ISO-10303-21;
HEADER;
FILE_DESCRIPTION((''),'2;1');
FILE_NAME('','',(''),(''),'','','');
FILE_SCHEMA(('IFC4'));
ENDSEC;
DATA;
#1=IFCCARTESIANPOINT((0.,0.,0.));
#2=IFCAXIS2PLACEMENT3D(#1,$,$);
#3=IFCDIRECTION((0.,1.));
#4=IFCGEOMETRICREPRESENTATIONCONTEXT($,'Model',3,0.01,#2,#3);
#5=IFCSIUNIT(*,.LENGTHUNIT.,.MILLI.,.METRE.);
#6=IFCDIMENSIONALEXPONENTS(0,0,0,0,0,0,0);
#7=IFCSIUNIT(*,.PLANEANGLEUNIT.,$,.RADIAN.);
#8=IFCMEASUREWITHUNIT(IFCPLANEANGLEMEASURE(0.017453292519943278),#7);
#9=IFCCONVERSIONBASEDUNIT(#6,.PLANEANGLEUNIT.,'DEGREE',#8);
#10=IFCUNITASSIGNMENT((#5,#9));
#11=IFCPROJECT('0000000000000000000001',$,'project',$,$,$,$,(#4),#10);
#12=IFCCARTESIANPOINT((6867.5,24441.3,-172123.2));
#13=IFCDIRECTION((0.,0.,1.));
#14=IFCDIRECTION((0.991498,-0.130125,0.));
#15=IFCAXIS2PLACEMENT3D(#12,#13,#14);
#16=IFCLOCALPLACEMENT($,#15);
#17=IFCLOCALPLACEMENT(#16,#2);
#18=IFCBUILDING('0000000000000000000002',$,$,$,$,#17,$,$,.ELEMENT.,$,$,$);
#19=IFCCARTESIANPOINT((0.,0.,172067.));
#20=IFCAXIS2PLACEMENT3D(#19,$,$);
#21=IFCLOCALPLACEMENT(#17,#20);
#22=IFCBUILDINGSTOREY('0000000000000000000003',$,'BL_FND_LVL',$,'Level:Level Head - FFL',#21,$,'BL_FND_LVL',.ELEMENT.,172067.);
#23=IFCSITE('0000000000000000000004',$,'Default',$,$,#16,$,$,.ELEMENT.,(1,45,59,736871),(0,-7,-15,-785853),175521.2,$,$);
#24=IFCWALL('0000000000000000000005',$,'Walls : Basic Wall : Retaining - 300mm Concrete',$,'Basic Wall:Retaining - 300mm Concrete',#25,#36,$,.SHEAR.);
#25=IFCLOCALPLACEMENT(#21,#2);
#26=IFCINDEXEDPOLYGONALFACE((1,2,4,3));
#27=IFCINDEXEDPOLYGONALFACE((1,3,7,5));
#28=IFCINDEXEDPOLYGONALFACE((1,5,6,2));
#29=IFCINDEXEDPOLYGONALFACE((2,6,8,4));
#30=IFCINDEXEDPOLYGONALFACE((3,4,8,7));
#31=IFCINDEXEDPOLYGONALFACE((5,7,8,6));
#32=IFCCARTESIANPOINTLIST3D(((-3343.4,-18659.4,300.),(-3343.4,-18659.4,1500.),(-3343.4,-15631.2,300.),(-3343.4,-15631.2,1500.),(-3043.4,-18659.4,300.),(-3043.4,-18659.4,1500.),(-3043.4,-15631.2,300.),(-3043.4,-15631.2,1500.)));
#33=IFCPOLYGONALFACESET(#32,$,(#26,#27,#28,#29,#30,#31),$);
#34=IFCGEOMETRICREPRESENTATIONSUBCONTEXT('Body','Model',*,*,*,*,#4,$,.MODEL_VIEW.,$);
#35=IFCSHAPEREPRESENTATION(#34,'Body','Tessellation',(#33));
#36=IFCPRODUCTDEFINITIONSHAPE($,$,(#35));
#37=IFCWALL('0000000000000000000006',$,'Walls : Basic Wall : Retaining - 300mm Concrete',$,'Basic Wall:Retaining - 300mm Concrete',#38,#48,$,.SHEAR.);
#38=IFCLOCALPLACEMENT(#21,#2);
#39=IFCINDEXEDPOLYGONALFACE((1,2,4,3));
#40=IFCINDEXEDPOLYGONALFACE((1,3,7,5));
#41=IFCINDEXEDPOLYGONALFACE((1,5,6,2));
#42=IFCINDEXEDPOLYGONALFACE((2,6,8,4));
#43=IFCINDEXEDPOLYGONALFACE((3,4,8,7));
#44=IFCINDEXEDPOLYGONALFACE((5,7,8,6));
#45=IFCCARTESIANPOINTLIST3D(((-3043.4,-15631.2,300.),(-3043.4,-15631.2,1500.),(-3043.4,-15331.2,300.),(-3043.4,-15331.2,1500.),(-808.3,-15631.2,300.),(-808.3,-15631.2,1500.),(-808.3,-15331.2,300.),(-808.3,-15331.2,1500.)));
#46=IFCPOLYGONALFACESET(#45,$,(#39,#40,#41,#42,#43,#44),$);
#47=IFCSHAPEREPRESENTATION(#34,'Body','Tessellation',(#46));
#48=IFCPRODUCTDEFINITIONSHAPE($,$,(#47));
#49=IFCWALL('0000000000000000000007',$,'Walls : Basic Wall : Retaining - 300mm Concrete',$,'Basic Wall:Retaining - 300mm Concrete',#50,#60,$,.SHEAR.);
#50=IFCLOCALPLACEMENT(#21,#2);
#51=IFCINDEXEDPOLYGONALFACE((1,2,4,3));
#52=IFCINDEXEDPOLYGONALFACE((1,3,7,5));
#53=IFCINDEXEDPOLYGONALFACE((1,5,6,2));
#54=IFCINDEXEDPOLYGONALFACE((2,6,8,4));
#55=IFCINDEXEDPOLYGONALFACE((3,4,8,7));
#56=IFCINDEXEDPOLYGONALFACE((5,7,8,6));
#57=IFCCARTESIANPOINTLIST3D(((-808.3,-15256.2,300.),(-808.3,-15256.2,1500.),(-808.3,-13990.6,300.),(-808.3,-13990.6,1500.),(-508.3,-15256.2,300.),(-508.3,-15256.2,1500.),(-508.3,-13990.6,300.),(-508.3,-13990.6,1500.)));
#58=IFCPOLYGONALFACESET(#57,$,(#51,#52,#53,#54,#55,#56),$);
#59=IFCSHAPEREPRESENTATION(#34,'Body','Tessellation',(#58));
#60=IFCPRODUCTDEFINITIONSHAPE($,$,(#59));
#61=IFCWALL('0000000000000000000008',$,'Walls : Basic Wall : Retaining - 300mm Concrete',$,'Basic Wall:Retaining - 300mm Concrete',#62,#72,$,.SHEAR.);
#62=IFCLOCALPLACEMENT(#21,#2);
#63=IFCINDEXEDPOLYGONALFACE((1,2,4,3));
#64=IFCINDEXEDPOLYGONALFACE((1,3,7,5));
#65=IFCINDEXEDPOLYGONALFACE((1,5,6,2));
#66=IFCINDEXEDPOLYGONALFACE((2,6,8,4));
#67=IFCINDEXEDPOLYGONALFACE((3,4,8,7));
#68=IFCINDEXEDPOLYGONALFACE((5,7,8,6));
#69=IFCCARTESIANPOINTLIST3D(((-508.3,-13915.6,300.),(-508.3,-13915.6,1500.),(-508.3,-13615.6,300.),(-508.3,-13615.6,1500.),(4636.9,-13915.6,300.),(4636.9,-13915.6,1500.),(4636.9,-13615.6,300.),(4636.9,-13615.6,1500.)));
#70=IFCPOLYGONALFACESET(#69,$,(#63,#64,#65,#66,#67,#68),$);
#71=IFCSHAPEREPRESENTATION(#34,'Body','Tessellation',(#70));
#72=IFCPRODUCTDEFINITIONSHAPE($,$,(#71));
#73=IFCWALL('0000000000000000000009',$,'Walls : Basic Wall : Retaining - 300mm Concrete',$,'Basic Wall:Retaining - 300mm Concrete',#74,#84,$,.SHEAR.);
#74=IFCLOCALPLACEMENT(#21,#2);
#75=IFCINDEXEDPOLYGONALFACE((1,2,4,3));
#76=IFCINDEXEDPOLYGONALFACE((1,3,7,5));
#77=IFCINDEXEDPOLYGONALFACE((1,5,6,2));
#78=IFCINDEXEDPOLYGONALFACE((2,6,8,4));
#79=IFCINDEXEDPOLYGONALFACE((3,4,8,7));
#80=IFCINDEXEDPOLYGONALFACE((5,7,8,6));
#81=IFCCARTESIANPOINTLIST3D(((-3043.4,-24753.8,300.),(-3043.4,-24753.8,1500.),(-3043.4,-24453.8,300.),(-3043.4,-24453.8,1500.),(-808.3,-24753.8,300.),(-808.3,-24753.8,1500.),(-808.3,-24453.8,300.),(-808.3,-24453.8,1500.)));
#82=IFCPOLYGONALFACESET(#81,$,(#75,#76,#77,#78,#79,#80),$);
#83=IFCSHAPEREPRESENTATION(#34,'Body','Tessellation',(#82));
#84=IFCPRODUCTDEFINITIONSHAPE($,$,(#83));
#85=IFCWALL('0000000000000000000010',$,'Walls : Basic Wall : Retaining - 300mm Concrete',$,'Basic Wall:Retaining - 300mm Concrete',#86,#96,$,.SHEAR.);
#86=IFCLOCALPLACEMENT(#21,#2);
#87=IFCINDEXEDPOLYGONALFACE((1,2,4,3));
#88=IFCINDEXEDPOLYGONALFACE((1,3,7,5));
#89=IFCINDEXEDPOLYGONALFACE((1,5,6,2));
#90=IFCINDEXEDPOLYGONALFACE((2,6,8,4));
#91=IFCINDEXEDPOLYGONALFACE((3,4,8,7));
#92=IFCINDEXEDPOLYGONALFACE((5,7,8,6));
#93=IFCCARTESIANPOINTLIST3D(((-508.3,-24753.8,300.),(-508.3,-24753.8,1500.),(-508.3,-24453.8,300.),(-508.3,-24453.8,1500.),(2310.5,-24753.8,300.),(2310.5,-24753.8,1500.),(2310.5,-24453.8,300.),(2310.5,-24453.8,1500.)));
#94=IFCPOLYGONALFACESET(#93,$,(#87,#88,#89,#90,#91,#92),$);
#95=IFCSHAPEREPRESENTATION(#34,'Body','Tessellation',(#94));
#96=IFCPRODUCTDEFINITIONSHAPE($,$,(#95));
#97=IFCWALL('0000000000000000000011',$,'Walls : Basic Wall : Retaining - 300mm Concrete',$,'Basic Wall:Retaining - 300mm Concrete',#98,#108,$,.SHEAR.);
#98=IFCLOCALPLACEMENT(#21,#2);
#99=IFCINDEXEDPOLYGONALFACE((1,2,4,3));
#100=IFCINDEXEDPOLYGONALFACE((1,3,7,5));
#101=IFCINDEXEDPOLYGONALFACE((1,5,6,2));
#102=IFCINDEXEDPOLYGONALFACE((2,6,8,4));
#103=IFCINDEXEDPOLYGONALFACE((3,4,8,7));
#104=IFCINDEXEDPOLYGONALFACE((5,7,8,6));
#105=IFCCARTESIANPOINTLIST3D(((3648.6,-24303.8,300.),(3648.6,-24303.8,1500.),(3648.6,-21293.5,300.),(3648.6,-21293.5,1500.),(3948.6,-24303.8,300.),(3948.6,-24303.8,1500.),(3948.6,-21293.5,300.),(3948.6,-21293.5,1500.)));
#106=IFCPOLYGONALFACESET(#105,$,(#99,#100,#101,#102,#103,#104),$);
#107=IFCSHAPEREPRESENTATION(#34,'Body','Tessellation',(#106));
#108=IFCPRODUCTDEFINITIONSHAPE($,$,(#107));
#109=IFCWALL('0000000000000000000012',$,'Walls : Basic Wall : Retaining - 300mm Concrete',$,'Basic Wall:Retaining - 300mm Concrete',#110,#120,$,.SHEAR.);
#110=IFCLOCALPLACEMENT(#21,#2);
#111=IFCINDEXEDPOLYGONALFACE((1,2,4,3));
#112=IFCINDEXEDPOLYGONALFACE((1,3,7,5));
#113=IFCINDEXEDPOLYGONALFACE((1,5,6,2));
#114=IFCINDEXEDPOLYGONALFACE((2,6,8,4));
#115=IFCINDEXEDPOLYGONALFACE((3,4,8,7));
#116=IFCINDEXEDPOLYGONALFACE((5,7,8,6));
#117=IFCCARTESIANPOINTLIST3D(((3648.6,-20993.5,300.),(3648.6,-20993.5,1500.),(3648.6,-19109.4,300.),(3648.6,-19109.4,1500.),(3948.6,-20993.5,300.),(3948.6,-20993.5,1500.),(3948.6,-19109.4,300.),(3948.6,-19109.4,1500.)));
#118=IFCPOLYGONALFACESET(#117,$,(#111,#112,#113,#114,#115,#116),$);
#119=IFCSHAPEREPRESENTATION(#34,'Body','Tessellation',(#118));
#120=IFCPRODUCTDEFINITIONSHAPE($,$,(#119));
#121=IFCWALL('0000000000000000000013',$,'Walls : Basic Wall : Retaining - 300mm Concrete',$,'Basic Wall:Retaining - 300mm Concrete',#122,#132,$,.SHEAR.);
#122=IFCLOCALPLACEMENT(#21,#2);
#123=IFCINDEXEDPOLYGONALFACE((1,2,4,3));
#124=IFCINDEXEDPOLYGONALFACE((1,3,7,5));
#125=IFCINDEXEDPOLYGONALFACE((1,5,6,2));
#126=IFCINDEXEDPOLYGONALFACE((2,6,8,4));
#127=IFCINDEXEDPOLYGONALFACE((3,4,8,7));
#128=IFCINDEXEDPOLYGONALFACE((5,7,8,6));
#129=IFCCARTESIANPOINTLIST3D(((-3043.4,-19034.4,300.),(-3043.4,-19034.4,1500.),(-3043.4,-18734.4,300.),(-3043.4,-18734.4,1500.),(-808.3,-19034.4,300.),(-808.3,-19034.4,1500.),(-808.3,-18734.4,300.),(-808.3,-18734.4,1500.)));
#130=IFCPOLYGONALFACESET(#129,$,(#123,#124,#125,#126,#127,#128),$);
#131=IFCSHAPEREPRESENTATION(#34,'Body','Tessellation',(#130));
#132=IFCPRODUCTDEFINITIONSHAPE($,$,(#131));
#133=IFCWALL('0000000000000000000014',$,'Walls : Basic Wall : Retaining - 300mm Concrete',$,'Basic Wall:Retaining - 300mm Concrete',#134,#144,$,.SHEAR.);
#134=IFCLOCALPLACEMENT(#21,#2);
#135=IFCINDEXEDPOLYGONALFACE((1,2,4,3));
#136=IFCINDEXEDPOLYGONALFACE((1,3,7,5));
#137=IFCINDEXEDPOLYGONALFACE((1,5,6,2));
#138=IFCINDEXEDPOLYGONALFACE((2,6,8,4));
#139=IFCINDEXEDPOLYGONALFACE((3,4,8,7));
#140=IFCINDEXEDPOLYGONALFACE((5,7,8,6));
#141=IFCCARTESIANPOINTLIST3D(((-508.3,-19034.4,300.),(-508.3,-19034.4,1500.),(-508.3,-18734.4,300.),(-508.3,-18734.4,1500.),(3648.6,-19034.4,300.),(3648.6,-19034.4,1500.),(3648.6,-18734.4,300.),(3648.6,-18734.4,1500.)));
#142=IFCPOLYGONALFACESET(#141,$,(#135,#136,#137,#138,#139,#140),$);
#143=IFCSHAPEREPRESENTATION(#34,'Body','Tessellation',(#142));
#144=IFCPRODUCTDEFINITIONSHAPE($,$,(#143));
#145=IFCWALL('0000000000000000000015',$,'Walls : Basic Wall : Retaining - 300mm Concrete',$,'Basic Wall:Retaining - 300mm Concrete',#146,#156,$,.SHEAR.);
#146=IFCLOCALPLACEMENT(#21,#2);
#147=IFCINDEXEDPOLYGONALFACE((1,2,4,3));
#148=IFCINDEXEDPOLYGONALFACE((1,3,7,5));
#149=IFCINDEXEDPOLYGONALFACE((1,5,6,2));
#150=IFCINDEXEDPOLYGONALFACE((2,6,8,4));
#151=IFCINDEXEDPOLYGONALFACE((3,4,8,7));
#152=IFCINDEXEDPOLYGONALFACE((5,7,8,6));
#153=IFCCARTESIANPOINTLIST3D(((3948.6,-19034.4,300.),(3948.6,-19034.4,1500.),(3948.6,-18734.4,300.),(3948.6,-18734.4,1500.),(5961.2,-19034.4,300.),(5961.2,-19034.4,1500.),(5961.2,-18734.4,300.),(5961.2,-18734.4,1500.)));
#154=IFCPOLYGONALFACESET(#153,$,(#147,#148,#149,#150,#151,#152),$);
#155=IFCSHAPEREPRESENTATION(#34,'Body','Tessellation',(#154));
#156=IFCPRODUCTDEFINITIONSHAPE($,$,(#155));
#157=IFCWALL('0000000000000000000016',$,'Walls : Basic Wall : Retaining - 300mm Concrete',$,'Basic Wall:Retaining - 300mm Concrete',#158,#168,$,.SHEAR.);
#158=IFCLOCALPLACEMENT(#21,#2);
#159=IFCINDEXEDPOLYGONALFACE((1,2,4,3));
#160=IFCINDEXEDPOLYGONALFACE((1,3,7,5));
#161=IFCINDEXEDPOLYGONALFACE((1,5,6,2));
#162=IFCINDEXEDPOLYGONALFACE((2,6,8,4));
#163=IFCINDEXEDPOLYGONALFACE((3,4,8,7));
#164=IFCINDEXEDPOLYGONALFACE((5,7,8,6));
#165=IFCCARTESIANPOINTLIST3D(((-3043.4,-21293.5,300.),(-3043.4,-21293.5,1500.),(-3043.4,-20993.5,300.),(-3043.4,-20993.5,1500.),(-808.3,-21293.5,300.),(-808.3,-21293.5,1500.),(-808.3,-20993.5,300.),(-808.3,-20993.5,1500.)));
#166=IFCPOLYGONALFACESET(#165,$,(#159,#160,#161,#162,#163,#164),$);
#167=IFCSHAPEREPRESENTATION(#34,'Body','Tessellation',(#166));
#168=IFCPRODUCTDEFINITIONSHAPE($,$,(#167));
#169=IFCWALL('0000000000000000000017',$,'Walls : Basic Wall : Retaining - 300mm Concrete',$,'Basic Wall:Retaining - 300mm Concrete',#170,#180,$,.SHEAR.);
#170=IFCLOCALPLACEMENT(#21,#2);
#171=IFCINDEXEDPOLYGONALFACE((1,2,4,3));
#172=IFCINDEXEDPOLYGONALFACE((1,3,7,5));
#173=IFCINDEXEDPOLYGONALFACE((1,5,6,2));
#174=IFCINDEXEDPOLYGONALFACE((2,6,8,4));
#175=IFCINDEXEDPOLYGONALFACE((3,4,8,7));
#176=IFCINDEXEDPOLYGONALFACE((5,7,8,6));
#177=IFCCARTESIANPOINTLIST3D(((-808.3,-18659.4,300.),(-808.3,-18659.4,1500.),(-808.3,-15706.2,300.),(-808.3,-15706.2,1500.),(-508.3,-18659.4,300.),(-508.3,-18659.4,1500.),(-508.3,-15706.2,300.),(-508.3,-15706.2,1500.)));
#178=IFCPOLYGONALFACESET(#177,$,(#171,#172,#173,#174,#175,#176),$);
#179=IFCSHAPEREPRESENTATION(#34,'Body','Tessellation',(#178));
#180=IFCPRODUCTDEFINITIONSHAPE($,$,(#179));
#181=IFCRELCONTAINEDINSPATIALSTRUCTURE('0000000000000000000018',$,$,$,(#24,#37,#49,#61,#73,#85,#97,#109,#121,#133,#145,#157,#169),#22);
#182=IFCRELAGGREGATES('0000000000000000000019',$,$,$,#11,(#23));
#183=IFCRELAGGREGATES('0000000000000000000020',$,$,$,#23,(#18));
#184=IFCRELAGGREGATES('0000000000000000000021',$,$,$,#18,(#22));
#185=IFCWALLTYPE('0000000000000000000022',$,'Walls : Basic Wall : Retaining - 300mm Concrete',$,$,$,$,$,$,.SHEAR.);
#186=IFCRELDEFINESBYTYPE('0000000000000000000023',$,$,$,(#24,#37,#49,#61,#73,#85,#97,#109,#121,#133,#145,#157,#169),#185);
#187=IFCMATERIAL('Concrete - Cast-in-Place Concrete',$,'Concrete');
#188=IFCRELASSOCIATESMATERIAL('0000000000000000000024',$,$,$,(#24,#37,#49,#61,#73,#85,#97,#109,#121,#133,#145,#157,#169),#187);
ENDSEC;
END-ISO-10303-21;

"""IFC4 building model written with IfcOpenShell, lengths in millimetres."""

from ifc_helpers import new_model, entity, si_unit, converted_unit, direction, frame, origin, place, context, subcontext, project, spatial, indexed_curve, outline, extrude, material, type_object, element, save


model = new_model("IFC4")

# Units and contexts
model_context = context("Model", 3, precision=0.01, world=origin(), true_north=direction((0.0, 1.0)))
body_context = subcontext(model_context, "Body", "Model", "MODEL_VIEW")
ifc_project = project(units=[si_unit("LENGTHUNIT", "METRE", prefix="MILLI"), converted_unit("PLANEANGLEUNIT", "DEGREE", entity("IfcPlaneAngleMeasure", 0.017453292519943278), si_unit("PLANEANGLEUNIT", "RADIAN"), dimensions=[0, 0, 0, 0, 0, 0, 0])], contexts=[model_context])

# Site, building, storey
site_placement = place(None, frame((6867.5, 24441.3, -172123.2), z_axis=(0.0, 0.0, 1.0), x_axis=(0.991498, -0.130125, 0.0)))
site = spatial("IfcSite", under=ifc_project, at=site_placement, Name="Default", CompositionType="ELEMENT", RefLatitude=(1, 45, 59, 736871), RefLongitude=(0, -7, -15, -785853), RefElevation=175521.2)
building_placement = place(site_placement, origin())
building = spatial("IfcBuilding", under=site, at=building_placement, CompositionType="ELEMENT")
storey_placement = place(building_placement, frame((0.0, 0.0, 172067.0)))
storey = spatial("IfcBuildingStorey", under=building, at=storey_placement, Name="BL_FND_LVL", ObjectType="Level:Level Head - FFL", LongName="BL_FND_LVL", CompositionType="ELEMENT", Elevation=172067.0)

# Shared definitions
ifc_material_1 = material(Name="Concrete - Cast-in-Place Concrete", Category="Concrete")

# Walls
wall_type = type_object("IfcWallType", Name="Walls : Basic Wall : Retaining - 300mm Concrete", PredefinedType="SHEAR")
wall_1_placement = place(storey_placement, frame((-3193.4, -18659.4, 300.0), z_axis=(0.0, 0.0, 1.0), x_axis=(0.0, 1.0, 0.0)))
element("IfcWall", 1, at=wall_1_placement, inside=storey, type_object=wall_type, material=ifc_material_1, Name="Walls : Basic Wall : Retaining - 300mm Concrete", ObjectType="Basic Wall:Retaining - 300mm Concrete", PredefinedType="SHEAR", context=body_context, shape_type="SweptSolid", body=[
    extrude(outline(indexed_curve([(3028.2, 150.0), (0.0, 150.0), (0.0, -150.0), (3028.2, -150.0), (3028.2, 150.0)], self_intersect=False)), origin(), (0.0, 0.0, 1.0), 1200.0),
])
wall_2_placement = place(storey_placement, frame((-3043.4, -15481.2, 300.0)))
element("IfcWall", 2, at=wall_2_placement, inside=storey, type_object=wall_type, material=ifc_material_1, Name="Walls : Basic Wall : Retaining - 300mm Concrete", ObjectType="Basic Wall:Retaining - 300mm Concrete", PredefinedType="SHEAR", context=body_context, shape_type="SweptSolid", body=[
    extrude(outline(indexed_curve([(2235.1, 150.0), (0.0, 150.0), (0.0, -150.0), (2235.1, -150.0), (2235.1, 150.0)], self_intersect=False)), origin(), (0.0, 0.0, 1.0), 1200.0),
])
wall_3_placement = place(storey_placement, frame((-658.3, -15256.2, 300.0), z_axis=(0.0, 0.0, 1.0), x_axis=(0.0, 1.0, 0.0)))
element("IfcWall", 3, at=wall_3_placement, inside=storey, type_object=wall_type, material=ifc_material_1, Name="Walls : Basic Wall : Retaining - 300mm Concrete", ObjectType="Basic Wall:Retaining - 300mm Concrete", PredefinedType="SHEAR", context=body_context, shape_type="SweptSolid", body=[
    extrude(outline(indexed_curve([(1265.6, 150.0), (0.0, 150.0), (0.0, -150.0), (1265.6, -150.0), (1265.6, 150.0)], self_intersect=False)), origin(), (0.0, 0.0, 1.0), 1200.0),
])
wall_4_placement = place(storey_placement, frame((-508.3, -13765.6, 300.0)))
element("IfcWall", 4, at=wall_4_placement, inside=storey, type_object=wall_type, material=ifc_material_1, Name="Walls : Basic Wall : Retaining - 300mm Concrete", ObjectType="Basic Wall:Retaining - 300mm Concrete", PredefinedType="SHEAR", context=body_context, shape_type="SweptSolid", body=[
    extrude(outline(indexed_curve([(5145.2, 150.0), (0.0, 150.0), (0.0, -150.0), (5145.2, -150.0), (5145.2, 150.0)], self_intersect=False)), origin(), (0.0, 0.0, 1.0), 1200.0),
])
wall_5_placement = place(storey_placement, frame((-3043.4, -24603.8, 300.0)))
element("IfcWall", 5, at=wall_5_placement, inside=storey, type_object=wall_type, material=ifc_material_1, Name="Walls : Basic Wall : Retaining - 300mm Concrete", ObjectType="Basic Wall:Retaining - 300mm Concrete", PredefinedType="SHEAR", context=body_context, shape_type="SweptSolid", body=[
    extrude(outline(indexed_curve([(2235.1, 150.0), (0.0, 150.0), (0.0, -150.0), (2235.1, -150.0), (2235.1, 150.0)], self_intersect=False)), origin(), (0.0, 0.0, 1.0), 1200.0),
])
wall_6_placement = place(storey_placement, frame((-508.3, -24603.8, 300.0)))
element("IfcWall", 6, at=wall_6_placement, inside=storey, type_object=wall_type, material=ifc_material_1, Name="Walls : Basic Wall : Retaining - 300mm Concrete", ObjectType="Basic Wall:Retaining - 300mm Concrete", PredefinedType="SHEAR", context=body_context, shape_type="SweptSolid", body=[
    extrude(outline(indexed_curve([(2818.8, 150.0), (0.0, 150.0), (0.0, -150.0), (2818.8, -150.0), (2818.8, 150.0)], self_intersect=False)), origin(), (0.0, 0.0, 1.0), 1200.0),
])
wall_7_placement = place(storey_placement, frame((3798.6, -24303.8, 300.0), z_axis=(0.0, 0.0, 1.0), x_axis=(0.0, 1.0, 0.0)))
element("IfcWall", 7, at=wall_7_placement, inside=storey, type_object=wall_type, material=ifc_material_1, Name="Walls : Basic Wall : Retaining - 300mm Concrete", ObjectType="Basic Wall:Retaining - 300mm Concrete", PredefinedType="SHEAR", context=body_context, shape_type="SweptSolid", body=[
    extrude(outline(indexed_curve([(3010.3, 150.0), (0.0, 150.0), (0.0, -150.0), (3010.3, -150.0), (3010.3, 150.0)], self_intersect=False)), origin(), (0.0, 0.0, 1.0), 1200.0),
])
wall_8_placement = place(storey_placement, frame((3798.6, -20993.5, 300.0), z_axis=(0.0, 0.0, 1.0), x_axis=(0.0, 1.0, 0.0)))
element("IfcWall", 8, at=wall_8_placement, inside=storey, type_object=wall_type, material=ifc_material_1, Name="Walls : Basic Wall : Retaining - 300mm Concrete", ObjectType="Basic Wall:Retaining - 300mm Concrete", PredefinedType="SHEAR", context=body_context, shape_type="SweptSolid", body=[
    extrude(outline(indexed_curve([(1884.1, 150.0), (0.0, 150.0), (0.0, -150.0), (1884.1, -150.0), (1884.1, 150.0)], self_intersect=False)), origin(), (0.0, 0.0, 1.0), 1200.0),
])
wall_9_placement = place(storey_placement, frame((-3043.4, -18884.4, 300.0)))
element("IfcWall", 9, at=wall_9_placement, inside=storey, type_object=wall_type, material=ifc_material_1, Name="Walls : Basic Wall : Retaining - 300mm Concrete", ObjectType="Basic Wall:Retaining - 300mm Concrete", PredefinedType="SHEAR", context=body_context, shape_type="SweptSolid", body=[
    extrude(outline(indexed_curve([(2235.1, 150.0), (0.0, 150.0), (0.0, -150.0), (2235.1, -150.0), (2235.1, 150.0)], self_intersect=False)), origin(), (0.0, 0.0, 1.0), 1200.0),
])
wall_10_placement = place(storey_placement, frame((-508.3, -18884.4, 300.0)))
element("IfcWall", 10, at=wall_10_placement, inside=storey, type_object=wall_type, material=ifc_material_1, Name="Walls : Basic Wall : Retaining - 300mm Concrete", ObjectType="Basic Wall:Retaining - 300mm Concrete", PredefinedType="SHEAR", context=body_context, shape_type="SweptSolid", body=[
    extrude(outline(indexed_curve([(4156.9, 150.0), (0.0, 150.0), (0.0, -150.0), (4156.9, -150.0), (4156.9, 150.0)], self_intersect=False)), origin(), (0.0, 0.0, 1.0), 1200.0),
])
wall_11_placement = place(storey_placement, frame((3948.6, -18884.4, 300.0)))
element("IfcWall", 11, at=wall_11_placement, inside=storey, type_object=wall_type, material=ifc_material_1, Name="Walls : Basic Wall : Retaining - 300mm Concrete", ObjectType="Basic Wall:Retaining - 300mm Concrete", PredefinedType="SHEAR", context=body_context, shape_type="SweptSolid", body=[
    extrude(outline(indexed_curve([(2012.6, 150.0), (0.0, 150.0), (0.0, -150.0), (2012.6, -150.0), (2012.6, 150.0)], self_intersect=False)), origin(), (0.0, 0.0, 1.0), 1200.0),
])
wall_12_placement = place(storey_placement, frame((-3043.4, -21143.5, 300.0)))
element("IfcWall", 12, at=wall_12_placement, inside=storey, type_object=wall_type, material=ifc_material_1, Name="Walls : Basic Wall : Retaining - 300mm Concrete", ObjectType="Basic Wall:Retaining - 300mm Concrete", PredefinedType="SHEAR", context=body_context, shape_type="SweptSolid", body=[
    extrude(outline(indexed_curve([(2235.1, 150.0), (0.0, 150.0), (0.0, -150.0), (2235.1, -150.0), (2235.1, 150.0)], self_intersect=False)), origin(), (0.0, 0.0, 1.0), 1200.0),
])
wall_13_placement = place(storey_placement, frame((-658.3, -15706.2, 300.0), z_axis=(0.0, 0.0, 1.0), x_axis=(0.0, -1.0, 0.0)))
element("IfcWall", 13, at=wall_13_placement, inside=storey, type_object=wall_type, material=ifc_material_1, Name="Walls : Basic Wall : Retaining - 300mm Concrete", ObjectType="Basic Wall:Retaining - 300mm Concrete", PredefinedType="SHEAR", context=body_context, shape_type="SweptSolid", body=[
    extrude(outline(indexed_curve([(2953.2, 150.0), (0.0, 150.0), (0.0, -150.0), (2953.2, -150.0), (2953.2, 150.0)], self_intersect=False)), origin(), (0.0, 0.0, 1.0), 1200.0),
])

save(model, "model.ifc")
